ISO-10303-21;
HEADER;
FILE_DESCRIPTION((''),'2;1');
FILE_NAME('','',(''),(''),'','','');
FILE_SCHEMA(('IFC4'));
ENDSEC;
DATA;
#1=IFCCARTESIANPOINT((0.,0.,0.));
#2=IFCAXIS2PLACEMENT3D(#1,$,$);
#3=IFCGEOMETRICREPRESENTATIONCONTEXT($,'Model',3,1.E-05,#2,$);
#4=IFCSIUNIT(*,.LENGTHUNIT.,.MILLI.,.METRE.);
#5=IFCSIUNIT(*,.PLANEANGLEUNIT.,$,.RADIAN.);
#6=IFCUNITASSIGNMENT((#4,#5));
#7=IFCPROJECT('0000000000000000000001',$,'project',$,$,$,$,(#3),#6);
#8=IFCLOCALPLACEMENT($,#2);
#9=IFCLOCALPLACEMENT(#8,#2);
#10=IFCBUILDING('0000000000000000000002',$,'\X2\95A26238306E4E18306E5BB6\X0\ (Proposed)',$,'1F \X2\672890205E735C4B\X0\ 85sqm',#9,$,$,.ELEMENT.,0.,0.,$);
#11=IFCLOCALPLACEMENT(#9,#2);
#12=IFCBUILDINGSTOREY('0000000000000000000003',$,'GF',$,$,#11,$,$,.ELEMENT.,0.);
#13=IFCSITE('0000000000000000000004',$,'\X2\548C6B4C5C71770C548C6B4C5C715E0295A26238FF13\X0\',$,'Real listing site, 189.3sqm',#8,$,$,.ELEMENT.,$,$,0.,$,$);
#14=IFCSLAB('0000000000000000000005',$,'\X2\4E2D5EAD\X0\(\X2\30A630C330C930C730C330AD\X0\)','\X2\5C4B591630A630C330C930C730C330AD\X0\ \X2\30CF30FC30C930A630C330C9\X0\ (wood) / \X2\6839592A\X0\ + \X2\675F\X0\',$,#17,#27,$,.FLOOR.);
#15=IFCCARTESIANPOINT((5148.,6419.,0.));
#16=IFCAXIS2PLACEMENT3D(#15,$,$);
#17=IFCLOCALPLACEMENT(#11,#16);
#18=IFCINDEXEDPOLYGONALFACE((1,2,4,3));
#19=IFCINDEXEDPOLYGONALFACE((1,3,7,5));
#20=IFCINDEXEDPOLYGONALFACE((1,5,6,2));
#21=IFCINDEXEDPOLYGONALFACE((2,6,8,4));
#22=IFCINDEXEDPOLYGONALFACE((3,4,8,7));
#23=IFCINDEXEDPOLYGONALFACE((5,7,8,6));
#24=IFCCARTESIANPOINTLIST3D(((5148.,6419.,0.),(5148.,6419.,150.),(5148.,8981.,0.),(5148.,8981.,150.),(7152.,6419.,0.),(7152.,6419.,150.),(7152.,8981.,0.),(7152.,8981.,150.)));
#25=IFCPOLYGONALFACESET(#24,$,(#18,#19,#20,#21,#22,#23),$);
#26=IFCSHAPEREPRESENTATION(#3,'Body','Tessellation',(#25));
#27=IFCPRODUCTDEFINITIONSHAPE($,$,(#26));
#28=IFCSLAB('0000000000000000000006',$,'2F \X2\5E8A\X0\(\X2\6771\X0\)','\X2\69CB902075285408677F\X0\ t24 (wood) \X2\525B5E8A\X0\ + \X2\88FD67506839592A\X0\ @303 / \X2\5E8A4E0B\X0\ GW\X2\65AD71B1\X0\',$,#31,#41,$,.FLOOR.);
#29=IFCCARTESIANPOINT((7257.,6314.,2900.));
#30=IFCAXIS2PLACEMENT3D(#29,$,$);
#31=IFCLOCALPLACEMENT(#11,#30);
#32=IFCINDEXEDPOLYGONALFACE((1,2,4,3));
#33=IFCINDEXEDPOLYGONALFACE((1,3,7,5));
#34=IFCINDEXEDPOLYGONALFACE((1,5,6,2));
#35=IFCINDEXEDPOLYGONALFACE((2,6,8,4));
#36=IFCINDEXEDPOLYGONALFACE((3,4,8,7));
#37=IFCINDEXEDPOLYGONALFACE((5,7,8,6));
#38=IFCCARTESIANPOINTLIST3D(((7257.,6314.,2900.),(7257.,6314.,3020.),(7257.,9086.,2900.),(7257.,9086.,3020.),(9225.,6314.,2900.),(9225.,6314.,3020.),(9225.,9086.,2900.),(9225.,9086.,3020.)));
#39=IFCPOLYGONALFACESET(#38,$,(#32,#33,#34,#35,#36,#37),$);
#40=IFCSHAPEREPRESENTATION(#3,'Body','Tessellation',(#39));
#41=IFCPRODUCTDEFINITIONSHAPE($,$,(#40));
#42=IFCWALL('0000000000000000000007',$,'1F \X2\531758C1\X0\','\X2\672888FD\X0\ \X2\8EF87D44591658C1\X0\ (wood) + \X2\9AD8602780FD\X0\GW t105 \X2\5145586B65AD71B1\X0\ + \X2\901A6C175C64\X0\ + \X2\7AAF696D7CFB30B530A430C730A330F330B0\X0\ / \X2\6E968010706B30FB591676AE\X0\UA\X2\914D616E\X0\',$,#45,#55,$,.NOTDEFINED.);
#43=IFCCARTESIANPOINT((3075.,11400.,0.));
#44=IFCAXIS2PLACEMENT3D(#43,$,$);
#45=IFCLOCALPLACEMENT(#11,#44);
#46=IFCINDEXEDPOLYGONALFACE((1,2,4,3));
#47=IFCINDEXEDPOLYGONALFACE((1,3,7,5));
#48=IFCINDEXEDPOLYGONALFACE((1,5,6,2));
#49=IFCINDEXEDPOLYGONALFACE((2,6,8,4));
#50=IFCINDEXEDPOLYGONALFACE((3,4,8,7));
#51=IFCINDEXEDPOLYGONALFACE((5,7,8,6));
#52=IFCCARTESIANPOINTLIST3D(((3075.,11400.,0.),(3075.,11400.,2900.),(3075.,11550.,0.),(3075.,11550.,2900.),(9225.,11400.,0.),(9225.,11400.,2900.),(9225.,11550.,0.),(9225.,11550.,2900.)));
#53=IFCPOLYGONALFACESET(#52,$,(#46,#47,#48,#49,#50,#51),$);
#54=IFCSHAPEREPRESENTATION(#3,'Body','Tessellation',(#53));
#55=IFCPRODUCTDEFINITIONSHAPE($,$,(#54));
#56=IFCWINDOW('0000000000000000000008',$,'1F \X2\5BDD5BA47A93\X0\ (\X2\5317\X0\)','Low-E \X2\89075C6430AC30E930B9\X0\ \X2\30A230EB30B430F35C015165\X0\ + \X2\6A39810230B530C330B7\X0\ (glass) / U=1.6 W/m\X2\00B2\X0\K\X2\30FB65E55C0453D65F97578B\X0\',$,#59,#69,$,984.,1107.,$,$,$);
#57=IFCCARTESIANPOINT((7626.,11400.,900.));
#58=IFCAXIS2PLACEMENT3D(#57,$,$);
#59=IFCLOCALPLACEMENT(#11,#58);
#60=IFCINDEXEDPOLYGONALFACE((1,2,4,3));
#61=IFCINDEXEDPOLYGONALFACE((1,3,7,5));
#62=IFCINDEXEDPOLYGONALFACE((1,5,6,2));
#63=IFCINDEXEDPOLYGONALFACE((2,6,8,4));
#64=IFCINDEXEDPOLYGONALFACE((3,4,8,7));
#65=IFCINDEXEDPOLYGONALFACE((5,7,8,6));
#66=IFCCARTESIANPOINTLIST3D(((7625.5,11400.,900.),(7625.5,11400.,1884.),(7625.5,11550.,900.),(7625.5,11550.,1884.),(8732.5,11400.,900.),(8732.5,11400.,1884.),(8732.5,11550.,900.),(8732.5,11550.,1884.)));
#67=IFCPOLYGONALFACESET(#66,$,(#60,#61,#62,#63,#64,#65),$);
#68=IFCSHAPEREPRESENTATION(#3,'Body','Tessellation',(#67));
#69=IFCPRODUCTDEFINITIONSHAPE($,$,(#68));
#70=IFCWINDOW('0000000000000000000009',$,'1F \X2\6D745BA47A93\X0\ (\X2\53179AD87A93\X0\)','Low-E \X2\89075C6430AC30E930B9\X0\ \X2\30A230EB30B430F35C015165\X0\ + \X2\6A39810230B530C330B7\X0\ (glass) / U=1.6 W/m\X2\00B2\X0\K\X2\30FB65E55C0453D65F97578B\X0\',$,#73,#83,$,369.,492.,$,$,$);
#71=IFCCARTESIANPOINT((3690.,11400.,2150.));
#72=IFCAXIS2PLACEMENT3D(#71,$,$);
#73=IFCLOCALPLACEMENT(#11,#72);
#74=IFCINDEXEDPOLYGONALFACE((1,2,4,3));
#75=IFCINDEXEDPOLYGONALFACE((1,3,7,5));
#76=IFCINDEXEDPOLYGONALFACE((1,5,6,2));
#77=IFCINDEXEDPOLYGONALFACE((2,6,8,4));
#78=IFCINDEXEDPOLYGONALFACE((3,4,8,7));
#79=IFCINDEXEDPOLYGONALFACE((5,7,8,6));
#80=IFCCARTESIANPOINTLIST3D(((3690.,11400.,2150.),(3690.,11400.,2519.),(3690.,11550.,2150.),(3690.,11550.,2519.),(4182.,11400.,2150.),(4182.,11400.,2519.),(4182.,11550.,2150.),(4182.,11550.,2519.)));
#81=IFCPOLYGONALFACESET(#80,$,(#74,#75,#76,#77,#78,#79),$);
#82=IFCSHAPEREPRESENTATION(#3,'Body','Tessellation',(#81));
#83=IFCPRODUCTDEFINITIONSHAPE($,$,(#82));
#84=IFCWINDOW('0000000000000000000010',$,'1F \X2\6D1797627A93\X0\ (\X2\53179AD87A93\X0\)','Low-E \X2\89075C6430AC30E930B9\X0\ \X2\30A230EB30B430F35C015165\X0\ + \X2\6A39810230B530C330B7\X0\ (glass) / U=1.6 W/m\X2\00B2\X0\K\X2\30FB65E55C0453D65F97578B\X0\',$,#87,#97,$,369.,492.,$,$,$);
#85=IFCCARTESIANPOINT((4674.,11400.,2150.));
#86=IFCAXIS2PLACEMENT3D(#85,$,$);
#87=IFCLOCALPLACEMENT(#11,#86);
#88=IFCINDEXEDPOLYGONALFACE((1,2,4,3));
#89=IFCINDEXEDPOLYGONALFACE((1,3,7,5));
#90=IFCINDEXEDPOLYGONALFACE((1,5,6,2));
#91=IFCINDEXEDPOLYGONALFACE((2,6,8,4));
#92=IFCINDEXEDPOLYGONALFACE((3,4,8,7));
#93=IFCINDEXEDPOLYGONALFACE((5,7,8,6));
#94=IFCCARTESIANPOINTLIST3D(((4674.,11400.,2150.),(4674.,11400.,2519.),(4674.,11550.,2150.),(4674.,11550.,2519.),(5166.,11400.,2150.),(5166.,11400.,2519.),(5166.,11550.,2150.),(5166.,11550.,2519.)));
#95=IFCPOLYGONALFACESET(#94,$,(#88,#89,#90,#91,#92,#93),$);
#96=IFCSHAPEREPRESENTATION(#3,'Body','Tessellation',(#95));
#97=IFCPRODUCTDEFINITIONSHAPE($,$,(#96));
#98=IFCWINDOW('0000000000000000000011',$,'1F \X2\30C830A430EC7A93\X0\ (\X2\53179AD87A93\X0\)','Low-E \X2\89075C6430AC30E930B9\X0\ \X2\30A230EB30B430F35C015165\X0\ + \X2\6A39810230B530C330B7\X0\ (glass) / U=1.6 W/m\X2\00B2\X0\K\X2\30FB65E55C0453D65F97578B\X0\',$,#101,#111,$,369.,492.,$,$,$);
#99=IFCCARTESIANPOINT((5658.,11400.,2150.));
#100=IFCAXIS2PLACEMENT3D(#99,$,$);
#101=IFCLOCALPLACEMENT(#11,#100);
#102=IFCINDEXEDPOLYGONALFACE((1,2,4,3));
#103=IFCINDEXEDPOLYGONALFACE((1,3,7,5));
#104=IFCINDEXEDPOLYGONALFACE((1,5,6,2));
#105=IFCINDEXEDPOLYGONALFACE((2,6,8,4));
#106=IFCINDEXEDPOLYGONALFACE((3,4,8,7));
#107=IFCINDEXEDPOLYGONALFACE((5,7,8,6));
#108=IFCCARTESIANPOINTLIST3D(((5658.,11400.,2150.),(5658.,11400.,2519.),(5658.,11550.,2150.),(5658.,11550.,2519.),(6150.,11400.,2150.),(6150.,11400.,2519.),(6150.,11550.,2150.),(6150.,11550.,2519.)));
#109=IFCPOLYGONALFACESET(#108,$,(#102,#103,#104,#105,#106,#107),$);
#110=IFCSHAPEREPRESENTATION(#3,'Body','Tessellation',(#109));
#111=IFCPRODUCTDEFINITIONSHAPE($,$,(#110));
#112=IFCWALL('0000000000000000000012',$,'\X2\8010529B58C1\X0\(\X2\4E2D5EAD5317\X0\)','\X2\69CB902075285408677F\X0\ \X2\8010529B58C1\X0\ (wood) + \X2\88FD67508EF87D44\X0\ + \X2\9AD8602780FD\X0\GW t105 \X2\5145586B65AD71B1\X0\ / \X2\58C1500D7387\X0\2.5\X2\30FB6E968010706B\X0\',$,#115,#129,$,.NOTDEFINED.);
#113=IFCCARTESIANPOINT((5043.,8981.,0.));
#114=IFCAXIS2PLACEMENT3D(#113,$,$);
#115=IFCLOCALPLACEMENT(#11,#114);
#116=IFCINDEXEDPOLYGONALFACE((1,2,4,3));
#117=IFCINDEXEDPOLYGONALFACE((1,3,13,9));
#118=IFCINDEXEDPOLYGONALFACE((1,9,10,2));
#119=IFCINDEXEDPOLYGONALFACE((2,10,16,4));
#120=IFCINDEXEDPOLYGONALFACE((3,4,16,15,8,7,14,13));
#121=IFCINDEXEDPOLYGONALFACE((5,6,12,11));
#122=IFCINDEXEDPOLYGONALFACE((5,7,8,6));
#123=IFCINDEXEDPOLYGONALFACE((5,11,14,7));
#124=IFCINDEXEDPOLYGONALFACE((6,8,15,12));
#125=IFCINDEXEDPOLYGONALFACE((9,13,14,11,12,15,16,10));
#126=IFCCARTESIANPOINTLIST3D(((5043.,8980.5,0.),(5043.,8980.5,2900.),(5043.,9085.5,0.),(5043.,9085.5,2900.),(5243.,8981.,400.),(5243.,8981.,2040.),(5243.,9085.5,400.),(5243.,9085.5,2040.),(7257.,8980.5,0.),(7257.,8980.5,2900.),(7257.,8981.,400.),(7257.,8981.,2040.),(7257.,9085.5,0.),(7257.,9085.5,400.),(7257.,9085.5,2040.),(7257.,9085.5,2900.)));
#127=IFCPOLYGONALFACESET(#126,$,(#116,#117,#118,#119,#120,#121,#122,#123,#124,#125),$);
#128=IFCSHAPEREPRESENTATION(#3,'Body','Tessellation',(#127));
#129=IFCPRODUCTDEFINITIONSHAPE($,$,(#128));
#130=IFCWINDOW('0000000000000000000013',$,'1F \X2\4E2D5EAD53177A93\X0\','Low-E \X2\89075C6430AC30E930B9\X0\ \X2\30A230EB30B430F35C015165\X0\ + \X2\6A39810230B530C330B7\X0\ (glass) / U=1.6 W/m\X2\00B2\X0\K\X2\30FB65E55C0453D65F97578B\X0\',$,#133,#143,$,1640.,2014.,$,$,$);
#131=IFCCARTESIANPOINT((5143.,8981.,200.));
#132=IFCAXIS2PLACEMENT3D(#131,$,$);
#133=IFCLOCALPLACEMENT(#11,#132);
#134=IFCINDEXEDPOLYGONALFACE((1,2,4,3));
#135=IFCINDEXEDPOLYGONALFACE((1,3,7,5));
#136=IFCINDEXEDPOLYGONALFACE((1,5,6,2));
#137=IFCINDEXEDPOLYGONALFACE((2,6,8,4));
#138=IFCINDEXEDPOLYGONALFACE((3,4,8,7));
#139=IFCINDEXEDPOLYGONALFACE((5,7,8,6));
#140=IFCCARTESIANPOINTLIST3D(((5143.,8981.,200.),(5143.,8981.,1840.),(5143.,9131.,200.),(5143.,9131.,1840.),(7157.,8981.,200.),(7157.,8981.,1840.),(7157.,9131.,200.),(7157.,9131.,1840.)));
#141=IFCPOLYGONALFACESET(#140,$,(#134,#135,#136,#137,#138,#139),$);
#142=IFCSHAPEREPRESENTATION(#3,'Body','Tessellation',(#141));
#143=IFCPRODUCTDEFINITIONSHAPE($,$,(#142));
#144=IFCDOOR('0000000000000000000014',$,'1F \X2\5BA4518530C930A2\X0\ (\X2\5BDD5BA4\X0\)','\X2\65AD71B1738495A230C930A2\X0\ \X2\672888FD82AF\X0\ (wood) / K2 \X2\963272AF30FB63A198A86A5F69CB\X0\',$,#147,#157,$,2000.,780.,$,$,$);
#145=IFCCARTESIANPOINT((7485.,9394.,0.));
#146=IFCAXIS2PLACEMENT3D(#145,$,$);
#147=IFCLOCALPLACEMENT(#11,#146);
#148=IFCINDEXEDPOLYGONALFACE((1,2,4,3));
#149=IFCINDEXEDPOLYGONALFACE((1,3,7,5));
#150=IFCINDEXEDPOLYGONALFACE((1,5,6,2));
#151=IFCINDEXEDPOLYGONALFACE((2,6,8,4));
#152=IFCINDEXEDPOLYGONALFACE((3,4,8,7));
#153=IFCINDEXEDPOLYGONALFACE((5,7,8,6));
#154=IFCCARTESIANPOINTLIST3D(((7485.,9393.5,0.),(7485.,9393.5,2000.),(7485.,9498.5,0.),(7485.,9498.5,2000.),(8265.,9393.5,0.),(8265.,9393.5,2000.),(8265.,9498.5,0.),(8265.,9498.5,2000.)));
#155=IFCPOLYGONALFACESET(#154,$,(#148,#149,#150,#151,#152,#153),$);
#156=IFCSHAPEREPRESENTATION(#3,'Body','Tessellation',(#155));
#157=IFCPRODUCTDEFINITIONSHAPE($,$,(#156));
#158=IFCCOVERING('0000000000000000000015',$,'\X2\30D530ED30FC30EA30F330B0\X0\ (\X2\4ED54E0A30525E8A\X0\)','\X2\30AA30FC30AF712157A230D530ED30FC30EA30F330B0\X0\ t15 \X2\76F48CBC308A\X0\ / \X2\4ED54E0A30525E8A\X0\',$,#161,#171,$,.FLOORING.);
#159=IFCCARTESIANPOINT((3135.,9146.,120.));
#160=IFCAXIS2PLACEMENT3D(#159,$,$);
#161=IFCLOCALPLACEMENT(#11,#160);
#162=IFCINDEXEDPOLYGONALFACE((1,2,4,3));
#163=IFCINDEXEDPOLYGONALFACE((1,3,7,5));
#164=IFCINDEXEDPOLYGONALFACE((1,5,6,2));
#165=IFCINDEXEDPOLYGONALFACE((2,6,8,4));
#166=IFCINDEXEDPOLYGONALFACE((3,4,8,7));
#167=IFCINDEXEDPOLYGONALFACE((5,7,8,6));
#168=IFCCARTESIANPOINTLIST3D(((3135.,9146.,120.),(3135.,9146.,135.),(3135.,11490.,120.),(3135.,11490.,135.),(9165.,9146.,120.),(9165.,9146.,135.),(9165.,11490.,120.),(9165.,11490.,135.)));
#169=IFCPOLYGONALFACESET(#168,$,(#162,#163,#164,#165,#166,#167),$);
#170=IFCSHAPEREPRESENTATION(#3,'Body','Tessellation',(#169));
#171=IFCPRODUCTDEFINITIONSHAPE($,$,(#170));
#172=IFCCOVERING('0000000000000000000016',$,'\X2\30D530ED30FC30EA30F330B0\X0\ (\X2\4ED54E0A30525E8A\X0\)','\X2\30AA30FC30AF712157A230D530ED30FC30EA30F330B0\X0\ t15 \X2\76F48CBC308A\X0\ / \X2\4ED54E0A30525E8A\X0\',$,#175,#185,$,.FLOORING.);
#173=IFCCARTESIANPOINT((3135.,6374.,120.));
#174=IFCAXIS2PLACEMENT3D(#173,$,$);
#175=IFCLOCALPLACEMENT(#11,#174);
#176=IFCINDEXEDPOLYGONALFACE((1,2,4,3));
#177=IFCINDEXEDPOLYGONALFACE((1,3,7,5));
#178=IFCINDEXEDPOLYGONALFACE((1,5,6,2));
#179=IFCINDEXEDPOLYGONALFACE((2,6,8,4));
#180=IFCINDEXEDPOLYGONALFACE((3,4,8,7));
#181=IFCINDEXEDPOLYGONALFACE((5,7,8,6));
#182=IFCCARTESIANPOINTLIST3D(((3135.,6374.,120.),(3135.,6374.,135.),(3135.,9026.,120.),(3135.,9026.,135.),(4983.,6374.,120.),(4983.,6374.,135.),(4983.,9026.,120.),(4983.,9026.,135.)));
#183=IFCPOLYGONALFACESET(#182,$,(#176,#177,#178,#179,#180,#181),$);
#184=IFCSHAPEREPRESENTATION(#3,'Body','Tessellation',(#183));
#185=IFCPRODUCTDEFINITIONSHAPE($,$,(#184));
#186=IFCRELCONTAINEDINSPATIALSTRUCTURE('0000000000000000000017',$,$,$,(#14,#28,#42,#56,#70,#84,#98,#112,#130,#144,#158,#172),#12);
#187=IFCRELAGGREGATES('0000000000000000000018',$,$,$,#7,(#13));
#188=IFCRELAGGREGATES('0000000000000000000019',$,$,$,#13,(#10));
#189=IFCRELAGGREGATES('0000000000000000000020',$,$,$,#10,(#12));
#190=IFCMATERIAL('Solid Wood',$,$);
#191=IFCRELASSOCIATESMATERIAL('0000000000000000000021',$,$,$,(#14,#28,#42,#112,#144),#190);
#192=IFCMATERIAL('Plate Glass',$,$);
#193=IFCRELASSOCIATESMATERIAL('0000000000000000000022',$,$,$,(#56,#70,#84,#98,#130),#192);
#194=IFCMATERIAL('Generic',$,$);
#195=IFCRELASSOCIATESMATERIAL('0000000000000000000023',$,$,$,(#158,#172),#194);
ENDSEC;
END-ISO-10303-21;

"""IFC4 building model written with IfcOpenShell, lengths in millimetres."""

from ifc_helpers import new_model, si_unit, frame, frame_2d, origin, place, context, project, spatial, rectangle, extrude, material, element, fill, save


model = new_model("IFC4")

# Units and contexts
model_context = context("Model", 3, precision=1e-05, world=origin())
ifc_project = project(units=[si_unit("LENGTHUNIT", "METRE", prefix="MILLI"), si_unit("PLANEANGLEUNIT", "RADIAN")], contexts=[model_context])

# Site, building, storey
site_placement = place(None, origin())
site = spatial("IfcSite", under=ifc_project, at=site_placement, Name="和歌山県和歌山市関戸３", ObjectType="Real listing site, 189.3sqm", CompositionType="ELEMENT", RefElevation=0.0)
building_placement = place(site_placement, origin())
building = spatial("IfcBuilding", under=site, at=building_placement, Name="関戸の丘の家 (Proposed)", ObjectType="1F 木造平屋 85sqm", CompositionType="ELEMENT", ElevationOfRefHeight=0.0, ElevationOfTerrain=0.0)
storey_placement = place(building_placement, origin())
storey = spatial("IfcBuildingStorey", under=building, at=storey_placement, Name="GF", CompositionType="ELEMENT", Elevation=0.0)

# Slabs
ifc_material_1 = material(Name="Solid Wood")
slab_1_placement = place(storey_placement, frame((5148.0, 6419.0, 0.0)))
element("IfcSlab", 1, at=slab_1_placement, inside=storey, material=ifc_material_1, Name="中庭(ウッドデッキ)", Description="屋外ウッドデッキ ハードウッド (wood) / 根太 + 束", PredefinedType="FLOOR", context=model_context, shape_type="SweptSolid", body=[
    extrude(rectangle(XDim=2004.0, YDim=2562.0, at=frame_2d((1002.0, 1281.0))), frame((5148.0, 6419.0, 0.0)), (0.0, 0.0, 1.0), 150.0),
])
slab_2_placement = place(storey_placement, frame((7257.0, 6314.0, 2900.0)))
element("IfcSlab", 2, at=slab_2_placement, inside=storey, material=ifc_material_1, Name="2F 床(東)", Description="構造用合板 t24 (wood) 剛床 + 製材根太 @303 / 床下 GW断熱", PredefinedType="FLOOR", context=model_context, shape_type="SweptSolid", body=[
    extrude(rectangle(XDim=1968.0, YDim=2772.0, at=frame_2d((984.0, 1386.0))), frame((7257.0, 6314.0, 2900.0)), (0.0, 0.0, 1.0), 120.0),
])

# Wall, openings, windows
wall_1_placement = place(storey_placement, frame((3075.0, 11400.0, 0.0)))
wall_1 = element("IfcWall", 3, at=wall_1_placement, inside=storey, material=ifc_material_1, Name="1F 北壁", Description="木製 軸組外壁 (wood) + 高性能GW t105 充填断熱 + 通気層 + 窯業系サイディング / 準耐火・外皮UA配慮", PredefinedType="NOTDEFINED", context=model_context, shape_type="SweptSolid", body=[
    extrude(rectangle(XDim=6150.0, YDim=150.0, at=frame_2d((3075.0, 75.0))), frame((3075.0, 11400.0, 0.0)), (0.0, 0.0, 1.0), 2900.0),
])
opening_1_placement = place(storey_placement, frame((7626.0, 11400.0, 900.0)))
opening_1 = element("IfcOpeningElement", 4, at=opening_1_placement, cuts=wall_1, PredefinedType="NOTDEFINED", context=model_context, shape_type="SweptSolid", body=[
    extrude(rectangle(XDim=1107.0, YDim=150.0, at=frame_2d((553.0, 75.0))), frame((7626.0, 11400.0, 900.0)), (0.0, 0.0, 1.0), 984.0),
])
opening_2_placement = place(storey_placement, frame((3690.0, 11400.0, 2150.0)))
opening_2 = element("IfcOpeningElement", 5, at=opening_2_placement, cuts=wall_1, PredefinedType="NOTDEFINED", context=model_context, shape_type="SweptSolid", body=[
    extrude(rectangle(XDim=492.0, YDim=150.0, at=frame_2d((246.0, 75.0))), frame((3690.0, 11400.0, 2150.0)), (0.0, 0.0, 1.0), 369.0),
])
opening_3_placement = place(storey_placement, frame((4674.0, 11400.0, 2150.0)))
opening_3 = element("IfcOpeningElement", 6, at=opening_3_placement, cuts=wall_1, PredefinedType="NOTDEFINED", context=model_context, shape_type="SweptSolid", body=[
    extrude(rectangle(XDim=492.0, YDim=150.0, at=frame_2d((246.0, 75.0))), frame((4674.0, 11400.0, 2150.0)), (0.0, 0.0, 1.0), 369.0),
])
opening_4_placement = place(storey_placement, frame((5658.0, 11400.0, 2150.0)))
opening_4 = element("IfcOpeningElement", 7, at=opening_4_placement, cuts=wall_1, PredefinedType="NOTDEFINED", context=model_context, shape_type="SweptSolid", body=[
    extrude(rectangle(XDim=492.0, YDim=150.0, at=frame_2d((246.0, 75.0))), frame((5658.0, 11400.0, 2150.0)), (0.0, 0.0, 1.0), 369.0),
])
ifc_material_2 = material(Name="Plate Glass")
window_1_placement = place(storey_placement, frame((7626.0, 11400.0, 900.0)))
window_1 = element("IfcWindow", 8, at=window_1_placement, inside=storey, material=ifc_material_2, Name="1F 寝室窓 (北)", Description="Low-E 複層ガラス アルゴン封入 + 樹脂サッシ (glass) / U=1.6 W/m²K・日射取得型", OverallHeight=984.0, OverallWidth=1107.0, context=model_context, shape_type="SweptSolid", body=[
    extrude(rectangle(XDim=1107.0, YDim=150.0, at=frame_2d((553.0, 75.0))), frame((7626.0, 11400.0, 900.0)), (0.0, 0.0, 1.0), 984.0),
])
fill(opening_1, window_1)
window_2_placement = place(storey_placement, frame((3690.0, 11400.0, 2150.0)))
window_2 = element("IfcWindow", 9, at=window_2_placement, inside=storey, material=ifc_material_2, Name="1F 浴室窓 (北高窓)", Description="Low-E 複層ガラス アルゴン封入 + 樹脂サッシ (glass) / U=1.6 W/m²K・日射取得型", OverallHeight=369.0, OverallWidth=492.0, context=model_context, shape_type="SweptSolid", body=[
    extrude(rectangle(XDim=492.0, YDim=150.0, at=frame_2d((246.0, 75.0))), frame((3690.0, 11400.0, 2150.0)), (0.0, 0.0, 1.0), 369.0),
])
fill(opening_2, window_2)
window_3_placement = place(storey_placement, frame((4674.0, 11400.0, 2150.0)))
window_3 = element("IfcWindow", 10, at=window_3_placement, inside=storey, material=ifc_material_2, Name="1F 洗面窓 (北高窓)", Description="Low-E 複層ガラス アルゴン封入 + 樹脂サッシ (glass) / U=1.6 W/m²K・日射取得型", OverallHeight=369.0, OverallWidth=492.0, context=model_context, shape_type="SweptSolid", body=[
    extrude(rectangle(XDim=492.0, YDim=150.0, at=frame_2d((246.0, 75.0))), frame((4674.0, 11400.0, 2150.0)), (0.0, 0.0, 1.0), 369.0),
])
fill(opening_3, window_3)
window_4_placement = place(storey_placement, frame((5658.0, 11400.0, 2150.0)))
window_4 = element("IfcWindow", 11, at=window_4_placement, inside=storey, material=ifc_material_2, Name="1F トイレ窓 (北高窓)", Description="Low-E 複層ガラス アルゴン封入 + 樹脂サッシ (glass) / U=1.6 W/m²K・日射取得型", OverallHeight=369.0, OverallWidth=492.0, context=model_context, shape_type="SweptSolid", body=[
    extrude(rectangle(XDim=492.0, YDim=150.0, at=frame_2d((246.0, 75.0))), frame((5658.0, 11400.0, 2150.0)), (0.0, 0.0, 1.0), 369.0),
])
fill(opening_4, window_4)

# Wall, opening, window
wall_2_placement = place(storey_placement, frame((5043.0, 8981.0, 0.0)))
wall_2 = element("IfcWall", 12, at=wall_2_placement, inside=storey, material=ifc_material_1, Name="耐力壁(中庭北)", Description="構造用合板 耐力壁 (wood) + 製材軸組 + 高性能GW t105 充填断熱 / 壁倍率2.5・準耐火", PredefinedType="NOTDEFINED", context=model_context, shape_type="SweptSolid", body=[
    extrude(rectangle(XDim=2214.0, YDim=105.0, at=frame_2d((1107.0, 52.0))), frame((5043.0, 8981.0, 0.0)), (0.0, 0.0, 1.0), 2900.0),
])
opening_5_placement = place(storey_placement, frame((5143.0, 8981.0, 200.0)))
opening_5 = element("IfcOpeningElement", 13, at=opening_5_placement, cuts=wall_2, PredefinedType="NOTDEFINED", context=model_context, shape_type="SweptSolid", body=[
    extrude(rectangle(XDim=2014.0, YDim=150.0, at=frame_2d((1007.0, 75.0))), frame((5143.0, 8981.0, 200.0)), (0.0, 0.0, 1.0), 1640.0),
])
window_5_placement = place(storey_placement, frame((5143.0, 8981.0, 200.0)))
window_5 = element("IfcWindow", 14, at=window_5_placement, inside=storey, material=ifc_material_2, Name="1F 中庭北窓", Description="Low-E 複層ガラス アルゴン封入 + 樹脂サッシ (glass) / U=1.6 W/m²K・日射取得型", OverallHeight=1640.0, OverallWidth=2014.0, context=model_context, shape_type="SweptSolid", body=[
    extrude(rectangle(XDim=2014.0, YDim=150.0, at=frame_2d((1007.0, 75.0))), frame((5143.0, 8981.0, 200.0)), (0.0, 0.0, 1.0), 1640.0),
])
fill(opening_5, window_5)

# Door
door_1_placement = place(storey_placement, frame((7485.0, 9394.0, 0.0)))
element("IfcDoor", 15, at=door_1_placement, inside=storey, material=ifc_material_1, Name="1F 室内ドア (寝室)", Description="断熱玄関ドア 木製芯 (wood) / K2 防犯・採風機構", OverallHeight=2000.0, OverallWidth=780.0, context=model_context, shape_type="SweptSolid", body=[
    extrude(rectangle(XDim=780.0, YDim=105.0, at=frame_2d((390.0, 52.0))), frame((7485.0, 9394.0, 0.0)), (0.0, 0.0, 1.0), 2000.0),
])

# Coverings
ifc_material_3 = material(Name="Generic")
covering_1_placement = place(storey_placement, frame((3135.0, 9146.0, 120.0)))
element("IfcCovering", 16, at=covering_1_placement, inside=storey, material=ifc_material_3, Name="フローリング (仕上げ床)", Description="オーク無垢フローリング t15 直貼り / 仕上げ床", PredefinedType="FLOORING", context=model_context, shape_type="SweptSolid", body=[
    extrude(rectangle(XDim=6030.0, YDim=2344.0, at=frame_2d((3015.0, 1172.0))), frame((3135.0, 9146.0, 120.0)), (0.0, 0.0, 1.0), 15.0),
])
covering_2_placement = place(storey_placement, frame((3135.0, 6374.0, 120.0)))
element("IfcCovering", 17, at=covering_2_placement, inside=storey, material=ifc_material_3, Name="フローリング (仕上げ床)", Description="オーク無垢フローリング t15 直貼り / 仕上げ床", PredefinedType="FLOORING", context=model_context, shape_type="SweptSolid", body=[
    extrude(rectangle(XDim=1848.0, YDim=2652.0, at=frame_2d((924.0, 1326.0))), frame((3135.0, 6374.0, 120.0)), (0.0, 0.0, 1.0), 15.0),
])

save(model, "model.ifc")
